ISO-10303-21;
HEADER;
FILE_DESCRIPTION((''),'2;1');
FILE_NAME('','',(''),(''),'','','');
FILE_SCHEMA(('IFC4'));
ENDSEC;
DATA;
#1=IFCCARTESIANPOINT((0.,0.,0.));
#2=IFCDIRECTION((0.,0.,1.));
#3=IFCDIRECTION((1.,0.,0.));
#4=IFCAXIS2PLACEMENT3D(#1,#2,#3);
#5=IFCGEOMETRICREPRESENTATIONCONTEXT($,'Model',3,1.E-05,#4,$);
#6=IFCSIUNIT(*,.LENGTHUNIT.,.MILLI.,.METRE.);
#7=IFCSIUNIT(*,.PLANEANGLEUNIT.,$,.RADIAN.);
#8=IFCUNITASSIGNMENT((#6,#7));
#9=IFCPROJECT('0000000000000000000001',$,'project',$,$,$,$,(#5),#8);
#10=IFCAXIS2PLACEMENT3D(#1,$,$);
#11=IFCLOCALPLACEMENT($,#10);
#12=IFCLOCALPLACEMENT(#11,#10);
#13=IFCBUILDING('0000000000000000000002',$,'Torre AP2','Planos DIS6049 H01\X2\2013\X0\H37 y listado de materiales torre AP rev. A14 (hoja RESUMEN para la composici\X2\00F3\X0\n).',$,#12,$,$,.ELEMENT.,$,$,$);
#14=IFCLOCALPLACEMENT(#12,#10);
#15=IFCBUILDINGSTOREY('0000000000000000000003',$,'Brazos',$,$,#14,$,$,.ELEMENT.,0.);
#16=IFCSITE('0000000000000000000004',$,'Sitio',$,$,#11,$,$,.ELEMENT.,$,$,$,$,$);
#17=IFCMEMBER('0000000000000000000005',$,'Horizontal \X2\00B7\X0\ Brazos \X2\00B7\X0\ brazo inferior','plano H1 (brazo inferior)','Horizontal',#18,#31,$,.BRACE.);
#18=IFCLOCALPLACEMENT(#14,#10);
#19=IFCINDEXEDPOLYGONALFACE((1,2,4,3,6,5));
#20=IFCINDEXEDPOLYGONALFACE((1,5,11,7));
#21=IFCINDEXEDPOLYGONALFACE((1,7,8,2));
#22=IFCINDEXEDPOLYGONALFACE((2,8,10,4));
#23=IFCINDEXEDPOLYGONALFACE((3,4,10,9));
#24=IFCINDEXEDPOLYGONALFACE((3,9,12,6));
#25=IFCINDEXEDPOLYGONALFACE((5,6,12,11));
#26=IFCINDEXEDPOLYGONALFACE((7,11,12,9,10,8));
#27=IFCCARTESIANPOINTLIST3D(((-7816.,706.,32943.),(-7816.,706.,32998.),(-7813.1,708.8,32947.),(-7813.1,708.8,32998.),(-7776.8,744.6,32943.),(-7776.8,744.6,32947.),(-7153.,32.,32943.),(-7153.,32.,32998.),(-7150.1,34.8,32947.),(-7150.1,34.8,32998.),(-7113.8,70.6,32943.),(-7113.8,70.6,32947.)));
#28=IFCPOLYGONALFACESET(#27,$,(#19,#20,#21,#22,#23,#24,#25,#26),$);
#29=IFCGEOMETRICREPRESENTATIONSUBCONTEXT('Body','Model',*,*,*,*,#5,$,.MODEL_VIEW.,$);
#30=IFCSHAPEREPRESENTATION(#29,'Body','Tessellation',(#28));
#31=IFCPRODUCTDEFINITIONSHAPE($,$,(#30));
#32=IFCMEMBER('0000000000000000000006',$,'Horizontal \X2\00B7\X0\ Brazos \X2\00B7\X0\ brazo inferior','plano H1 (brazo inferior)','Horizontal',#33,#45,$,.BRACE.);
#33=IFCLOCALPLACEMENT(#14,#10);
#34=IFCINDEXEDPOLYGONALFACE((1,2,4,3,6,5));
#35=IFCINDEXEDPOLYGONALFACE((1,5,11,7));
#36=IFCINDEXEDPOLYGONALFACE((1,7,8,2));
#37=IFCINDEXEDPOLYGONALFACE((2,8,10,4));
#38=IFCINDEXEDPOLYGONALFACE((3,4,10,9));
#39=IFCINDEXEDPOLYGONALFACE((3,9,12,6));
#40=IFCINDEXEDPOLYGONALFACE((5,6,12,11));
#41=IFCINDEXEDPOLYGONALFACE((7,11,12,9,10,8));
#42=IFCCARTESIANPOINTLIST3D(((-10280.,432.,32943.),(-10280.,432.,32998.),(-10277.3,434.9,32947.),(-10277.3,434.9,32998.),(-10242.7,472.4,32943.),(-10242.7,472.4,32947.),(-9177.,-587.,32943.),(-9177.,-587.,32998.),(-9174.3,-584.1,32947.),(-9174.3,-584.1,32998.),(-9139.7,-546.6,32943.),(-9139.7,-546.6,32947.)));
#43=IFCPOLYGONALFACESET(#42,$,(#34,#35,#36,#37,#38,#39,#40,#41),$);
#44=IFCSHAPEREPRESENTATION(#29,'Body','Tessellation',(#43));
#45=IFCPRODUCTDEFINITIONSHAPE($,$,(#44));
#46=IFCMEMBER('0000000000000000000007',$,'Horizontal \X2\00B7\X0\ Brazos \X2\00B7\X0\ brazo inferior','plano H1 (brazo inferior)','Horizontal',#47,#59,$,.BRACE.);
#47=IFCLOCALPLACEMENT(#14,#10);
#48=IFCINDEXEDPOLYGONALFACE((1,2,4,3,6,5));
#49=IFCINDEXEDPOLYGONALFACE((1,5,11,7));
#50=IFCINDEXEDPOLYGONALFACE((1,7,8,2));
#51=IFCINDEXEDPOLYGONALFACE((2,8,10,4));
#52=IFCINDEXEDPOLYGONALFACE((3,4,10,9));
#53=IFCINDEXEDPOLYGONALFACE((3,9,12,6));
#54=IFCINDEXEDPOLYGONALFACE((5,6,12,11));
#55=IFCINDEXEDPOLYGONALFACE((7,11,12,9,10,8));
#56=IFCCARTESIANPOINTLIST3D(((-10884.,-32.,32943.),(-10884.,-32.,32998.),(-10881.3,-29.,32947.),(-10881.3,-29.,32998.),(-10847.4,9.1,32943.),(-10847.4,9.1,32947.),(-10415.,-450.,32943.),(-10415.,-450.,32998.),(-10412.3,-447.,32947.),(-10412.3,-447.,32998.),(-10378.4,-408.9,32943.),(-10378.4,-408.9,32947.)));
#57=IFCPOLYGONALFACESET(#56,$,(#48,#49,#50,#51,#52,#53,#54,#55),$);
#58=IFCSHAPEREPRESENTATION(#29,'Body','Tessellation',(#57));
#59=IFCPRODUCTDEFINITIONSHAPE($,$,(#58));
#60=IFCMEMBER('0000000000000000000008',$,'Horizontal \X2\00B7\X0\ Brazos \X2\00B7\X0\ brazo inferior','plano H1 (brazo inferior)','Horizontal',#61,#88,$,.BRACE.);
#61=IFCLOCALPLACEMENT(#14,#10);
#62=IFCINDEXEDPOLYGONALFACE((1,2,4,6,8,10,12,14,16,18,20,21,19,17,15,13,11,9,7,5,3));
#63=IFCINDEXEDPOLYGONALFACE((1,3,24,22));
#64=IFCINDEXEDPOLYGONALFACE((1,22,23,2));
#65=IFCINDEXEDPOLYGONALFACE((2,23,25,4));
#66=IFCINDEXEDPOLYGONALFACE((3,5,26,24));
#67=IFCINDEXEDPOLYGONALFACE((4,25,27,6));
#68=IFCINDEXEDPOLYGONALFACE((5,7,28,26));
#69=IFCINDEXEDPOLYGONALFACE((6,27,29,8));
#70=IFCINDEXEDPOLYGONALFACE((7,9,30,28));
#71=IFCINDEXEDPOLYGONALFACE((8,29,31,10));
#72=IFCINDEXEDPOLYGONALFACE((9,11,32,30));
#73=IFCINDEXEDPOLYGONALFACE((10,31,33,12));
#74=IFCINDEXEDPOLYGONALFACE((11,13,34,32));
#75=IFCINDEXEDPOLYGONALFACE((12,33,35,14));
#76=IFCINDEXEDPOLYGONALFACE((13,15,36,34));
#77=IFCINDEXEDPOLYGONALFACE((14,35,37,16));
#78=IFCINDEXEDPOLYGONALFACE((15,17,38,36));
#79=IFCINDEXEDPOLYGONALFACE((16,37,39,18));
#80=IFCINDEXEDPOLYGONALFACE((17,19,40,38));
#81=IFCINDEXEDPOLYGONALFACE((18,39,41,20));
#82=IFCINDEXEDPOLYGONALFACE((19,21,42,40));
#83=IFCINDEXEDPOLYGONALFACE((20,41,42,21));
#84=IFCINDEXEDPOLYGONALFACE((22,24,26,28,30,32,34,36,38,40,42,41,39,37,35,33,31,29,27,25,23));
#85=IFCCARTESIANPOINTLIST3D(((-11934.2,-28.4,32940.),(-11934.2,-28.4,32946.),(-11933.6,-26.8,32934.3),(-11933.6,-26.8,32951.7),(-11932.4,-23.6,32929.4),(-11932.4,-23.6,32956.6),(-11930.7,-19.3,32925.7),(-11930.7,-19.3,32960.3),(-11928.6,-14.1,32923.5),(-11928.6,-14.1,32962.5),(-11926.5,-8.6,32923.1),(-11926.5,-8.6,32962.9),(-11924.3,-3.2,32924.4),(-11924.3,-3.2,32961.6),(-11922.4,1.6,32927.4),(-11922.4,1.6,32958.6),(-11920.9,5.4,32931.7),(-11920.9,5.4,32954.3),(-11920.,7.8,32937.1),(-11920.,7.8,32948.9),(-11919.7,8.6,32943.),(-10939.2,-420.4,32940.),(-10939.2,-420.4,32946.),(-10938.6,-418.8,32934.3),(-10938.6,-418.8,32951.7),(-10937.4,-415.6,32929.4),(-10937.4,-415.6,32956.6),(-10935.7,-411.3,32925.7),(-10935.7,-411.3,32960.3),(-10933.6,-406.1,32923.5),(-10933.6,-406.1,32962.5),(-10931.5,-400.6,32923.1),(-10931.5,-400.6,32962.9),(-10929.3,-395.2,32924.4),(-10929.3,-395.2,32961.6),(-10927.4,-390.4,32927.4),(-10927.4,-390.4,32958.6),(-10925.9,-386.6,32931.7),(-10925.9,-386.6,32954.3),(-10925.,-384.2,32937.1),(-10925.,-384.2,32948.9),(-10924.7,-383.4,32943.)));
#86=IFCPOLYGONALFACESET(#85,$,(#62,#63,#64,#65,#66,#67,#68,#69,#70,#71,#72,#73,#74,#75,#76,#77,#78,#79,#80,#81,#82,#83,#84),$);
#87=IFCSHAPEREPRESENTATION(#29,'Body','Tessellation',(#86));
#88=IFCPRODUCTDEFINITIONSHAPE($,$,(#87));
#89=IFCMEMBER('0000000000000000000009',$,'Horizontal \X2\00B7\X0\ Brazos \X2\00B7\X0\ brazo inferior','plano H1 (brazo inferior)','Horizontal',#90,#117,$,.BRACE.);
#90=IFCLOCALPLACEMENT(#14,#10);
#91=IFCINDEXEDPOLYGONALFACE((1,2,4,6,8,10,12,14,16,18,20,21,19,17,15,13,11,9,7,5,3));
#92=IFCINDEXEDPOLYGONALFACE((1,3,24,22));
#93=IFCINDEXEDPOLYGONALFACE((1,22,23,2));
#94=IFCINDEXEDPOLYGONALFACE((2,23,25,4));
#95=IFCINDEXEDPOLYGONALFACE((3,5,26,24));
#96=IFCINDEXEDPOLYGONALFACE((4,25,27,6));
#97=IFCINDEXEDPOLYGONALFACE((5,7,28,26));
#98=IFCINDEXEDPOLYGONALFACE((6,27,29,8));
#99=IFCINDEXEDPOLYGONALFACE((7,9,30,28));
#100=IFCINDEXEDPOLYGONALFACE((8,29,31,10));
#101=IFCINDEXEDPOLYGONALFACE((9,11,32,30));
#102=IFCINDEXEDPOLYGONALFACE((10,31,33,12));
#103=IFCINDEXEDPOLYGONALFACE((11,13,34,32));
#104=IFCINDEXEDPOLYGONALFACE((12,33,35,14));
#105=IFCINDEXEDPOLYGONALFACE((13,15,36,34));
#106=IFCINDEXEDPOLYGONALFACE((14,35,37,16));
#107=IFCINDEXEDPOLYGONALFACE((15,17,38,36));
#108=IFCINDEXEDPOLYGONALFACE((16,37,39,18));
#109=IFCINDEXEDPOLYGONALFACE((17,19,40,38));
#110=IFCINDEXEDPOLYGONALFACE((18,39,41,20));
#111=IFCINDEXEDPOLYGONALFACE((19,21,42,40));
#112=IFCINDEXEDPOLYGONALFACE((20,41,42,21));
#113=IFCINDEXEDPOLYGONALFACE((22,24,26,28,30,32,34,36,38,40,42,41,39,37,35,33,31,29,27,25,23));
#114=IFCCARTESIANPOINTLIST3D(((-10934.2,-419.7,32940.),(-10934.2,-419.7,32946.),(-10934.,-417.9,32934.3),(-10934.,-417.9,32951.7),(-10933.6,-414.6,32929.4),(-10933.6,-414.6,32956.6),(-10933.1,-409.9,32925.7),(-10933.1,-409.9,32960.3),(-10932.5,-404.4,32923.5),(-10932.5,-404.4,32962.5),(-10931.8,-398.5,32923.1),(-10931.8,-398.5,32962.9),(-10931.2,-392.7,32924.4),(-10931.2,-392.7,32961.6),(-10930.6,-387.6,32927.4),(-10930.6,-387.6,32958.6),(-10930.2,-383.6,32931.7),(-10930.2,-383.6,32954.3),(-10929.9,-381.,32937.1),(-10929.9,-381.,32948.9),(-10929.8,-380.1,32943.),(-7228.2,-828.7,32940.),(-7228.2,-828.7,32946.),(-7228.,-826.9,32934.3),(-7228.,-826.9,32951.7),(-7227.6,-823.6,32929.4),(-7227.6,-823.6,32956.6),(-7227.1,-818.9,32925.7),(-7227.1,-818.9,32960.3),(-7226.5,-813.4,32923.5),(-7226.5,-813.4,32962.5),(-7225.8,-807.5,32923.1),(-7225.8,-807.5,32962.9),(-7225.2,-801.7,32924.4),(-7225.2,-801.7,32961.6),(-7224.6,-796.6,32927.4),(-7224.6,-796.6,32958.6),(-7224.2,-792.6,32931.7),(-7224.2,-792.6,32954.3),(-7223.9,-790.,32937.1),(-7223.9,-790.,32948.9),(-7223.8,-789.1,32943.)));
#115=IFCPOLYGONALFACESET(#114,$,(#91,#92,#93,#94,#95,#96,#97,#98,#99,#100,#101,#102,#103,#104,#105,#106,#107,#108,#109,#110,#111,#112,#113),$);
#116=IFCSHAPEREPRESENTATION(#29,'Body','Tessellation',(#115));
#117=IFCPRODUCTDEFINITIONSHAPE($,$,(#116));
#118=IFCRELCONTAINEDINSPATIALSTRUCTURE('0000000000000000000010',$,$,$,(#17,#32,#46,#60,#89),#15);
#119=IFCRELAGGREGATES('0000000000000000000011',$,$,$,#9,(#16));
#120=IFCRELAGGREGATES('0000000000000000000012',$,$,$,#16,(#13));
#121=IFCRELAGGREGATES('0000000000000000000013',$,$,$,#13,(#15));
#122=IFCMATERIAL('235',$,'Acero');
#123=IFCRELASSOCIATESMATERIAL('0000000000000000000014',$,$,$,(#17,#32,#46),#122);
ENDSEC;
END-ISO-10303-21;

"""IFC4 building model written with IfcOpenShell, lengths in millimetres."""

from ifc_helpers import new_model, si_unit, frame, frame_2d, origin, origin_with_axes, place, context, subcontext, project, spatial, circle, l_section, extrude, material, element, save


model = new_model("IFC4")

# Units and contexts
model_context = context("Model", 3, precision=1e-05, world=origin_with_axes())
body_context = subcontext(model_context, "Body", "Model", "MODEL_VIEW")
ifc_project = project(units=[si_unit("LENGTHUNIT", "METRE", prefix="MILLI"), si_unit("PLANEANGLEUNIT", "RADIAN")], contexts=[model_context])

# Site, building, storey
site_placement = place(None, origin())
site = spatial("IfcSite", under=ifc_project, at=site_placement, Name="Sitio", CompositionType="ELEMENT")
building_placement = place(site_placement, origin())
building = spatial("IfcBuilding", under=site, at=building_placement, Name="Torre AP2", Description="Planos DIS6049 H01–H37 y listado de materiales torre AP rev. A14 (hoja RESUMEN para la composición).", CompositionType="ELEMENT")
storey_placement = place(building_placement, origin())
storey = spatial("IfcBuildingStorey", under=building, at=storey_placement, Name="Brazos", CompositionType="ELEMENT", Elevation=0.0)

# Members
ifc_material_1 = material(Name="235", Category="Acero")
member_1_placement = place(storey_placement, frame((-7816.0, 706.0, 32943.0), z_axis=(0.701265, -0.7129, 0.0), x_axis=(0.7129, 0.701265, 0.0)))
element("IfcMember", 1, at=member_1_placement, inside=storey, material=ifc_material_1, Name="Horizontal · Brazos · brazo inferior", Description="plano H1 (brazo inferior)", ObjectType="Horizontal", PredefinedType="BRACE", context=body_context, shape_type="SweptSolid", body=[
    extrude(l_section(Depth=55.0, Width=55.0, Thickness=4.0, at=frame_2d((27.5, 27.5))), None, (0.0, 0.0, 1.0), 945.4),
])
member_2_placement = place(storey_placement, frame((-10280.0, 432.0, 32943.0), z_axis=(0.734523, -0.678584, 0.0), x_axis=(0.678584, 0.734523, 0.0)))
element("IfcMember", 2, at=member_2_placement, inside=storey, material=ifc_material_1, Name="Horizontal · Brazos · brazo inferior", Description="plano H1 (brazo inferior)", ObjectType="Horizontal", PredefinedType="BRACE", context=body_context, shape_type="SweptSolid", body=[
    extrude(l_section(Depth=55.0, Width=55.0, Thickness=4.0, at=frame_2d((27.5, 27.5))), None, (0.0, 0.0, 1.0), 1501.7),
])
member_3_placement = place(storey_placement, frame((-10884.0, -32.0, 32943.0), z_axis=(0.74653, -0.665351, 0.0), x_axis=(0.665351, 0.74653, 0.0)))
element("IfcMember", 3, at=member_3_placement, inside=storey, material=ifc_material_1, Name="Horizontal · Brazos · brazo inferior", Description="plano H1 (brazo inferior)", ObjectType="Horizontal", PredefinedType="BRACE", context=body_context, shape_type="SweptSolid", body=[
    extrude(l_section(Depth=55.0, Width=55.0, Thickness=4.0, at=frame_2d((27.5, 27.5))), None, (0.0, 0.0, 1.0), 628.2),
])
member_4_placement = place(storey_placement, frame((-11927.0, -10.0, 32943.0), z_axis=(0.930399, -0.366549, 0.0), x_axis=(0.366549, 0.930399, 0.0)))
element("IfcMember", 4, at=member_4_placement, inside=storey, Name="Horizontal · Brazos · brazo inferior", Description="plano H1 (brazo inferior)", ObjectType="Horizontal", PredefinedType="BRACE", context=body_context, shape_type="SweptSolid", body=[
    extrude(circle(Radius=20.0), None, (0.0, 0.0, 1.0), 1069.4),
])
member_5_placement = place(storey_placement, frame((-10932.0, -400.0, 32943.0), z_axis=(0.993965, -0.109696, 0.0), x_axis=(0.109696, 0.993965, 0.0)))
element("IfcMember", 5, at=member_5_placement, inside=storey, Name="Horizontal · Brazos · brazo inferior", Description="plano H1 (brazo inferior)", ObjectType="Horizontal", PredefinedType="BRACE", context=body_context, shape_type="SweptSolid", body=[
    extrude(circle(Radius=20.0), None, (0.0, 0.0, 1.0), 3728.5),
])

save(model, "model.ifc")
